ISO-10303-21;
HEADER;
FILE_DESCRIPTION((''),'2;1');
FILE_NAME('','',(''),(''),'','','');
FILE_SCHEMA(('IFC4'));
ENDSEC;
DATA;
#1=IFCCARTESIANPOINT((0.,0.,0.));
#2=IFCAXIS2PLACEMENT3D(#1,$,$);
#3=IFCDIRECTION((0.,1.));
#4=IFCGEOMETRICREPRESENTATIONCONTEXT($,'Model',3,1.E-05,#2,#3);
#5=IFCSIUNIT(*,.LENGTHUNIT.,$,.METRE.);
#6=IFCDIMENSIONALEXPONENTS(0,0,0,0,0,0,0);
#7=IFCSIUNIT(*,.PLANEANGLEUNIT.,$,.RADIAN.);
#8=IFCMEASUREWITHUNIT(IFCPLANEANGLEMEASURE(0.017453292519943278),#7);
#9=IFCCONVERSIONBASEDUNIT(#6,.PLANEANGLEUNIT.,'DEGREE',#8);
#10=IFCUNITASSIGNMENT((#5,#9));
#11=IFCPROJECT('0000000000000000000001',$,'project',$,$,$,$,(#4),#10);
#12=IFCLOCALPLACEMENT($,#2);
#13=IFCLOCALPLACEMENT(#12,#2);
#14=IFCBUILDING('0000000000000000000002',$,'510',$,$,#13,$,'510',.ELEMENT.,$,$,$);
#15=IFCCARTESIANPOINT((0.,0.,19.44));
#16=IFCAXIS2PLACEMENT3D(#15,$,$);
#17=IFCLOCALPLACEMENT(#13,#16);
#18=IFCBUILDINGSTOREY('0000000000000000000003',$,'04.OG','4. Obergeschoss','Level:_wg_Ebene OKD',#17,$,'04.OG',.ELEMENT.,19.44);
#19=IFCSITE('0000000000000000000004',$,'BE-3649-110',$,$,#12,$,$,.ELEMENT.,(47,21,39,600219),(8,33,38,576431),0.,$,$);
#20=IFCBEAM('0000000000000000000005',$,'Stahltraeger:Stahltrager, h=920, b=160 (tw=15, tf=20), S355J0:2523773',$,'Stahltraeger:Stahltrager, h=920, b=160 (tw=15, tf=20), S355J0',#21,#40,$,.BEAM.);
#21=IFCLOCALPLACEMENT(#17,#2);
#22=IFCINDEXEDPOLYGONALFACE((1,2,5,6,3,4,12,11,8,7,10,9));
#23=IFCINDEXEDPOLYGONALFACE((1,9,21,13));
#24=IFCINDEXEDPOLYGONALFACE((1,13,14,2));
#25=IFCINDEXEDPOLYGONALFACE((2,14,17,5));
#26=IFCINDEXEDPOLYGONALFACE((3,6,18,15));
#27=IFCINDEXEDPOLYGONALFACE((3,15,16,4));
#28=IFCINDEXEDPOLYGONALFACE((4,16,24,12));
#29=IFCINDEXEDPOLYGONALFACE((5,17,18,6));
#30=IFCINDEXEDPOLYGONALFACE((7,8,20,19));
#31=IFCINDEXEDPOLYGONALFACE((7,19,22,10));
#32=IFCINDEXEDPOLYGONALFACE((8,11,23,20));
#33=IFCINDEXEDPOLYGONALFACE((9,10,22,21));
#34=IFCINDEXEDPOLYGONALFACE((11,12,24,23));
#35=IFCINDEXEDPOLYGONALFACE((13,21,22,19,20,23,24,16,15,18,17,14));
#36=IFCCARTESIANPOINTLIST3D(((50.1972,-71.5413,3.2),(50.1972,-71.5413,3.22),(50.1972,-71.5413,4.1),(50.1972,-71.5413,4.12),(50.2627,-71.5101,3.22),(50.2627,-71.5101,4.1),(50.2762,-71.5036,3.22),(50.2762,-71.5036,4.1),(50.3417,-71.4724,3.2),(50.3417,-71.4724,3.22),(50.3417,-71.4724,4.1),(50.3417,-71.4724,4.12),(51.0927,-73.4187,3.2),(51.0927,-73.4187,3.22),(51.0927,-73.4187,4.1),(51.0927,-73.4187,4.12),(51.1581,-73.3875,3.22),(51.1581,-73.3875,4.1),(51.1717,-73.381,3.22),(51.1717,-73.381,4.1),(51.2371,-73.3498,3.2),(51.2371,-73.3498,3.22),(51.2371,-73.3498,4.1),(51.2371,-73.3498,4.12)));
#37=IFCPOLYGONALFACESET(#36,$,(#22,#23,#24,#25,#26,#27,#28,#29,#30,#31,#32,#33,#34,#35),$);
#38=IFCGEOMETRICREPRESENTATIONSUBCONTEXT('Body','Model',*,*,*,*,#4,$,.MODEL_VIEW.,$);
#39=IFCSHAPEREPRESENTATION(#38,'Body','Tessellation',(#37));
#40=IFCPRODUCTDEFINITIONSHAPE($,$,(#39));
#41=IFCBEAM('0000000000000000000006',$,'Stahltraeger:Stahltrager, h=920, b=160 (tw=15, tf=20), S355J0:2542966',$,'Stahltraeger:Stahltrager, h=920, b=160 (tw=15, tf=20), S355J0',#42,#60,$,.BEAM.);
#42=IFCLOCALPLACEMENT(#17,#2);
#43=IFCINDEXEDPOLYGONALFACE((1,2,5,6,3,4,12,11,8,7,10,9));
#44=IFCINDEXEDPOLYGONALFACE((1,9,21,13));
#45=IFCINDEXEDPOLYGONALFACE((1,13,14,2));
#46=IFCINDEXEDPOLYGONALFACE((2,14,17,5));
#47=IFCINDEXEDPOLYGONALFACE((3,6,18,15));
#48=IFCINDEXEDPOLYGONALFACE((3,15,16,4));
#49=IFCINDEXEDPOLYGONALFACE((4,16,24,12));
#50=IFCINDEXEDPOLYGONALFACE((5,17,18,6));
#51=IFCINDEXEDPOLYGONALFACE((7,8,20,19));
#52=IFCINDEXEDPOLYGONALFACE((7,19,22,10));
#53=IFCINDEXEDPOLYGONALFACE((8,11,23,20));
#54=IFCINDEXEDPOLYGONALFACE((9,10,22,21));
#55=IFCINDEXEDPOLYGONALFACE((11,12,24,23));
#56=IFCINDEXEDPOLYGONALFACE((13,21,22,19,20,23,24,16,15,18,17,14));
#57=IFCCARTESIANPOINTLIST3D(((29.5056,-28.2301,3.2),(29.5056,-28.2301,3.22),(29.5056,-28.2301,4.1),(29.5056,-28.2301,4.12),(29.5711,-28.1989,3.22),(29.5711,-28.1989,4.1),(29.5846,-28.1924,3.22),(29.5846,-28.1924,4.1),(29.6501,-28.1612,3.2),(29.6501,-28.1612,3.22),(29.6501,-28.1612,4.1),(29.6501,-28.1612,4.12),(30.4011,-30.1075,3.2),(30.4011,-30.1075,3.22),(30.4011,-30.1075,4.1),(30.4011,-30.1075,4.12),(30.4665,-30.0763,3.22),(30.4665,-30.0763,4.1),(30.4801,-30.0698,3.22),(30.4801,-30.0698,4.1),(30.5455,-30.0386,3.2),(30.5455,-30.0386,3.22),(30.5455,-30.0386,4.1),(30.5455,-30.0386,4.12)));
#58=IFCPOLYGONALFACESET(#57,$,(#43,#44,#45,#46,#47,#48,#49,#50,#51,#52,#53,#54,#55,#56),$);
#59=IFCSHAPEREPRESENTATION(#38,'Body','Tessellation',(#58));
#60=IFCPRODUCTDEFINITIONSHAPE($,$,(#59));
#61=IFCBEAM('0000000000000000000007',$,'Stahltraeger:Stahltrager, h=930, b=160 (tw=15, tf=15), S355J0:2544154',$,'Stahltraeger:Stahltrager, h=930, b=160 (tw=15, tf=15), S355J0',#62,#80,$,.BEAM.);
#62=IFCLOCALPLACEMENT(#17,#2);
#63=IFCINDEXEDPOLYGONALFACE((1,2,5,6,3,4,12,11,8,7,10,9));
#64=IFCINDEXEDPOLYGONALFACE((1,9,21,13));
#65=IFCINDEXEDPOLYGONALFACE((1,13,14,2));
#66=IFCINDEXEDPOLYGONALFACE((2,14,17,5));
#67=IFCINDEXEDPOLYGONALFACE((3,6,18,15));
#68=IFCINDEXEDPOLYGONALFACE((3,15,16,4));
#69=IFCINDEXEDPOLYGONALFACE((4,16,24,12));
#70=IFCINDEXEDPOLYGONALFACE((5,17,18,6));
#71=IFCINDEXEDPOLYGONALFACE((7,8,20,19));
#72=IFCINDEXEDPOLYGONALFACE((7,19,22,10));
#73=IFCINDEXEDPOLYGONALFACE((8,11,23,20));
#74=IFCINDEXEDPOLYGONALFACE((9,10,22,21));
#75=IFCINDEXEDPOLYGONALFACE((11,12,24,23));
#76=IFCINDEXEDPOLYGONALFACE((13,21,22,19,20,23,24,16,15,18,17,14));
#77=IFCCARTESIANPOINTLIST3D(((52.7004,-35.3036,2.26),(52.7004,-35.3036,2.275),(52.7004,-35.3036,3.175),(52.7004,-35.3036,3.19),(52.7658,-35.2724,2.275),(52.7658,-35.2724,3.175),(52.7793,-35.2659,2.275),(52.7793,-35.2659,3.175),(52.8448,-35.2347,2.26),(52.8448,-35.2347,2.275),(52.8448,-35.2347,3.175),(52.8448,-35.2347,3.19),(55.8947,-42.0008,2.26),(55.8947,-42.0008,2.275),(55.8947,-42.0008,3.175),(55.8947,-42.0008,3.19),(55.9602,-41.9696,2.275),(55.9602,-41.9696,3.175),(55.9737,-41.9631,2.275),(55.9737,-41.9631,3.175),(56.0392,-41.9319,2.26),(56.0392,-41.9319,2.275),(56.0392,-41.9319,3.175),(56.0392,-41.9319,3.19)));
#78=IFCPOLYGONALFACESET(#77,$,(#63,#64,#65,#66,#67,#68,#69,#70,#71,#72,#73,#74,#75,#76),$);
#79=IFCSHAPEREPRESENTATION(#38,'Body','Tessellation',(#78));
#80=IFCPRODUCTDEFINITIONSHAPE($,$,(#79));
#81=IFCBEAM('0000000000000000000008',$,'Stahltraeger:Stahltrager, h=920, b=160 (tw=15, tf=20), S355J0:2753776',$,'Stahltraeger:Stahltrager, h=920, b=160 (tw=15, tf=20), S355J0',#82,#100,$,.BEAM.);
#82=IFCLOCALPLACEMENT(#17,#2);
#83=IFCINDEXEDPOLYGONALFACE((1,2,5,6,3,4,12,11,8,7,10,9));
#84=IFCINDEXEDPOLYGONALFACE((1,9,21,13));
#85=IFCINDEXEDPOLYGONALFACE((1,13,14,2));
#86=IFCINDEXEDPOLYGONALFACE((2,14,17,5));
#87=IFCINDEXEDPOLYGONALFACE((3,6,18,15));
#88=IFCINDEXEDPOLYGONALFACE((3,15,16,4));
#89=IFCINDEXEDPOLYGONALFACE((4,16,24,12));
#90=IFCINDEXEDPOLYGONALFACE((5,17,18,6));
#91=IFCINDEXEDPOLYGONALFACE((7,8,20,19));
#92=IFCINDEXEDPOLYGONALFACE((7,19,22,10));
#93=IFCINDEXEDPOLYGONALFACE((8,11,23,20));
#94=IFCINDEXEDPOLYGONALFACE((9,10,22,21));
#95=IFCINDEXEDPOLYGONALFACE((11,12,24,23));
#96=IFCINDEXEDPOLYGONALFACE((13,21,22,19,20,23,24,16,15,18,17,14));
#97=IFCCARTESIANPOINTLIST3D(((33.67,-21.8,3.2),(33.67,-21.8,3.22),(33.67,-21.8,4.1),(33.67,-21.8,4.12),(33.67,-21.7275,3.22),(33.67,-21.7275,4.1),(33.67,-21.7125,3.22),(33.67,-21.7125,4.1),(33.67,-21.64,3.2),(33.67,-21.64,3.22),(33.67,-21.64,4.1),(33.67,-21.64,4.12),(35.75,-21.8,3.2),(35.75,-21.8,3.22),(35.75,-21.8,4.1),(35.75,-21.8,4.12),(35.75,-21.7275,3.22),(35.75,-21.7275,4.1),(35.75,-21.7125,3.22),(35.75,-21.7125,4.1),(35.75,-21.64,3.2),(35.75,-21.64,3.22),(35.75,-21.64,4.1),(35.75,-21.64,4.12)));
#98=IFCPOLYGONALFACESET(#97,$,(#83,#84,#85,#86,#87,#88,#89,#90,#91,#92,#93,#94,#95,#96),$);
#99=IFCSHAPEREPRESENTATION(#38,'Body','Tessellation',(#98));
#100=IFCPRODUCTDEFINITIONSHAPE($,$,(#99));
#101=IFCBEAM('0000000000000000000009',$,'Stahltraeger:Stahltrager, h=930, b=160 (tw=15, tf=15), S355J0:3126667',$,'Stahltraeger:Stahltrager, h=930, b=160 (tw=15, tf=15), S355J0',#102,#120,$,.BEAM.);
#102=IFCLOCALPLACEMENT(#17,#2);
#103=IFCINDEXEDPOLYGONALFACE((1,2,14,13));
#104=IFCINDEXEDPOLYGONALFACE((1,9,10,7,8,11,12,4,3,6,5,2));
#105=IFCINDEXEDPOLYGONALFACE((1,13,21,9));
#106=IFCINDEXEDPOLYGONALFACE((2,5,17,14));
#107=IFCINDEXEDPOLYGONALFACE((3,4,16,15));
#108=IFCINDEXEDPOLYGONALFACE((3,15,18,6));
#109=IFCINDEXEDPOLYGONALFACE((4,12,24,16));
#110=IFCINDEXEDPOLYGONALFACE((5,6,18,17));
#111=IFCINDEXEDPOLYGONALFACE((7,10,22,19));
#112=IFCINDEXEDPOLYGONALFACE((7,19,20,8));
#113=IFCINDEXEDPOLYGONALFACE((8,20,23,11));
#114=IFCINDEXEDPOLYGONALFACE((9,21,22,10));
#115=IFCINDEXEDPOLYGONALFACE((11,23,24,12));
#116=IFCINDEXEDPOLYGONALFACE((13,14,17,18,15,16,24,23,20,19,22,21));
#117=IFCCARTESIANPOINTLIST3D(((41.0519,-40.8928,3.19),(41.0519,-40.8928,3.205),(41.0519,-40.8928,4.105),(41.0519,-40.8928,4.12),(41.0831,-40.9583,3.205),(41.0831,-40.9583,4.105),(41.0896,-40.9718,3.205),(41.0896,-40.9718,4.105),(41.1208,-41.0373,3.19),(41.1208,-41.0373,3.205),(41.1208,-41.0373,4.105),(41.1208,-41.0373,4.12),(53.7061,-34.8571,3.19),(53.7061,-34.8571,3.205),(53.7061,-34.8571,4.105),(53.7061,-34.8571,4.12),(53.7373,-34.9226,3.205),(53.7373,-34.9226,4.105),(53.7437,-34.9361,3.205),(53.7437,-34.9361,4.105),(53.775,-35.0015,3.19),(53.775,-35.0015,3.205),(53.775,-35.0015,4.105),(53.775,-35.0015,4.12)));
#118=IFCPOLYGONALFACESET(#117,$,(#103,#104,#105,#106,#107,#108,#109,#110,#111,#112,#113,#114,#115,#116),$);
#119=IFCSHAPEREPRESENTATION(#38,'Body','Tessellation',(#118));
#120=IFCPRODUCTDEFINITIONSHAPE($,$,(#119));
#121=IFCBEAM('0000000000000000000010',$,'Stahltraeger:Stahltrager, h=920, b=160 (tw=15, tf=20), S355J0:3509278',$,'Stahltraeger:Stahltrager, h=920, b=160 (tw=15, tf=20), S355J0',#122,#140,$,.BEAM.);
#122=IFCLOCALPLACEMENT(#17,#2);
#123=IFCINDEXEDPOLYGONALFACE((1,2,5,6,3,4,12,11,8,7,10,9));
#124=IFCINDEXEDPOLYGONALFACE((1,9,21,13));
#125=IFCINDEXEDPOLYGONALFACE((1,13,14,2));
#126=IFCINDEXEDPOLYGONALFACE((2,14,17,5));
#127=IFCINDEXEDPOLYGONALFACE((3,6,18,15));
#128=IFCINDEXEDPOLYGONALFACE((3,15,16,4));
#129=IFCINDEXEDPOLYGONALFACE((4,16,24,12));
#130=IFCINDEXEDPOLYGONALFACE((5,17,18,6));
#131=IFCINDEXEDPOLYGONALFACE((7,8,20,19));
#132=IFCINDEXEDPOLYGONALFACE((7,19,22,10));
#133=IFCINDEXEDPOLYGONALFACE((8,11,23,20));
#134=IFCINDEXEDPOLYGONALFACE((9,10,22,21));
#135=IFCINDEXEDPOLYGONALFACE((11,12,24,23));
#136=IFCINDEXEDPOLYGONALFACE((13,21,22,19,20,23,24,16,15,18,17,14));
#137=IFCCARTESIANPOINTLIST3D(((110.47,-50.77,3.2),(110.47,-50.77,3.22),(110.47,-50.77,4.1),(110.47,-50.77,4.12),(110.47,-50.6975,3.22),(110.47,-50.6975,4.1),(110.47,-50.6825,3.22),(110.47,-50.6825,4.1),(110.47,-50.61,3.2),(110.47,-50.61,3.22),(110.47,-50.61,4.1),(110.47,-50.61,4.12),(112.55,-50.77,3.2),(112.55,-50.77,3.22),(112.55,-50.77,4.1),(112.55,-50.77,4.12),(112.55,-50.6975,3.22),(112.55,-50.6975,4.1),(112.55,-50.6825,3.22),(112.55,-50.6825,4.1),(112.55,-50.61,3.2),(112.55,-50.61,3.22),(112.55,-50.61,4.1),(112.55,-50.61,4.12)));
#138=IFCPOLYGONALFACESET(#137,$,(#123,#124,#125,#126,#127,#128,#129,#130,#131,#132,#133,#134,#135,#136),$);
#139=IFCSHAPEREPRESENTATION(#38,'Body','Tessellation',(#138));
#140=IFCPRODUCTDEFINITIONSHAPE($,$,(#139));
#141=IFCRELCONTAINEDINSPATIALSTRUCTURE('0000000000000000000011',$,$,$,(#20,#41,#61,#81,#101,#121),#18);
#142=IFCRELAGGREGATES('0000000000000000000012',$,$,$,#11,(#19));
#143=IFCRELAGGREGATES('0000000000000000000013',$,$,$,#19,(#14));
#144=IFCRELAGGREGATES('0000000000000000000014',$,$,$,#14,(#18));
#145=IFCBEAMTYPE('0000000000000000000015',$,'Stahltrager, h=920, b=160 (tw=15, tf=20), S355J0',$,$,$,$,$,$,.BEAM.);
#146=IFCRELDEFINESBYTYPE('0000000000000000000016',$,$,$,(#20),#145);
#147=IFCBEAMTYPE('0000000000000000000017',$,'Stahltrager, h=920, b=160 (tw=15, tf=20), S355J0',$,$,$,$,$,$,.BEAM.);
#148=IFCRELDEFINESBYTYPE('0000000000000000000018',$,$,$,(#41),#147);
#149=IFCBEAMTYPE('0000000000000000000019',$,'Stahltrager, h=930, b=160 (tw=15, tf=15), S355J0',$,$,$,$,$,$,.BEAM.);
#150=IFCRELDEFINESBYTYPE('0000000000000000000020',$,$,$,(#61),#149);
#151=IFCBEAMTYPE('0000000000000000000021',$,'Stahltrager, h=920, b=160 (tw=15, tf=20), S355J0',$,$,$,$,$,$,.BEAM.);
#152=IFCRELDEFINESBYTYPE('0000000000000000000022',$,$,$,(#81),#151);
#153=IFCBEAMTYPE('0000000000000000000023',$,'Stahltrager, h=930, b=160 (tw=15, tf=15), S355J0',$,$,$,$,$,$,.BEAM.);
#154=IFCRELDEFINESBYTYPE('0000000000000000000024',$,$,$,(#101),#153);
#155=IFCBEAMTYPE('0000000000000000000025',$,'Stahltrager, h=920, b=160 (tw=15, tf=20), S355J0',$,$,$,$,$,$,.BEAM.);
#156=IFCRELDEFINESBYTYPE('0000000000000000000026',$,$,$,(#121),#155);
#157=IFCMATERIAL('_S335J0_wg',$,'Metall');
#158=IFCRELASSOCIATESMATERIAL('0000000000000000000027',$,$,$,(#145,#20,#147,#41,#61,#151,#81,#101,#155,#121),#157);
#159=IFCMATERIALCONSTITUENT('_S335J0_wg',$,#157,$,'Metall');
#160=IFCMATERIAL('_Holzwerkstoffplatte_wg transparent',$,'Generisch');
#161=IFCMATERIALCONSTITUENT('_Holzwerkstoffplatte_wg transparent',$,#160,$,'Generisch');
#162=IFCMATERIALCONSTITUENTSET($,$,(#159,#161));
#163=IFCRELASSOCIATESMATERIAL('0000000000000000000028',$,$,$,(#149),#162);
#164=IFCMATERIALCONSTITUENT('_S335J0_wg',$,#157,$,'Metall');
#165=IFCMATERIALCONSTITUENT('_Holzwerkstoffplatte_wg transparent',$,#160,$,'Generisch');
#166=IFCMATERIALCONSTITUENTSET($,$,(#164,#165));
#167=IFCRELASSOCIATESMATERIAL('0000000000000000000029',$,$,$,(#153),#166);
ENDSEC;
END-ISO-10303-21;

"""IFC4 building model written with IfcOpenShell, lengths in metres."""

from ifc_helpers import new_model, entity, si_unit, converted_unit, direction, frame, origin, place, context, subcontext, project, spatial, indexed_curve, outline, extrude, source, transform, mapped, material, constituent, constituent_set, type_object, type_shapes, element, save


model = new_model("IFC4")

# Units and contexts
model_context = context("Model", 3, precision=1e-05, world=origin(), true_north=direction((0.0, 1.0)))
body_context = subcontext(model_context, "Body", "Model", "MODEL_VIEW")
ifc_project = project(units=[si_unit("LENGTHUNIT", "METRE"), converted_unit("PLANEANGLEUNIT", "DEGREE", entity("IfcPlaneAngleMeasure", 0.017453292519943278), si_unit("PLANEANGLEUNIT", "RADIAN"), dimensions=[0, 0, 0, 0, 0, 0, 0])], contexts=[model_context])

# Site, building, storey
site_placement = place(None, origin())
site = spatial("IfcSite", under=ifc_project, at=site_placement, Name="BE-3649-110", CompositionType="ELEMENT", RefLatitude=(47, 21, 39, 600219), RefLongitude=(8, 33, 38, 576431), RefElevation=0.0)
building_placement = place(site_placement, origin())
building = spatial("IfcBuilding", under=site, at=building_placement, Name="510", LongName="510", CompositionType="ELEMENT")
storey_placement = place(building_placement, frame((0.0, 0.0, 19.44)))
storey = spatial("IfcBuildingStorey", under=building, at=storey_placement, Name="04.OG", Description="4. Obergeschoss", ObjectType="Level:_wg_Ebene OKD", LongName="04.OG", CompositionType="ELEMENT", Elevation=19.44)

# Beams, openings
ifc_material_1 = material(Name="_S335J0_wg", Category="Metall")
beam_type_1 = type_object("IfcBeamType", Name="Stahltrager, h=920, b=160 (tw=15, tf=20), S355J0", PredefinedType="BEAM", material=ifc_material_1)
shared_shape_1 = source(origin(), body_context, "Body", "SweptSolid", [
    extrude(outline(indexed_curve([(-0.08, -0.44), (-0.08, -0.46), (0.08, -0.46), (0.08, -0.44), (0.0075, -0.44), (0.0075, 0.44), (0.08, 0.44), (0.08, 0.46), (-0.08, 0.46), (-0.08, 0.44), (-0.0075, 0.44), (-0.0075, -0.44), (-0.08, -0.44)], self_intersect=False)), frame((0.9677, 0.0344, 0.46), z_axis=(0.430511, -0.902585, 0.0), x_axis=(0.902585, 0.430511, 0.0)), (0.0, 0.0, -1.0), 2.08),
])
type_shapes(beam_type_1, [shared_shape_1])
beam_1_placement = place(storey_placement, frame((50.1972, -73.4187, 3.2)))
beam_1 = element("IfcBeam", 1, at=beam_1_placement, inside=storey, type_object=beam_type_1, material=ifc_material_1, Name="Stahltraeger:Stahltrager, h=920, b=160 (tw=15, tf=20), S355J0:2523773", ObjectType="Stahltraeger:Stahltrager, h=920, b=160 (tw=15, tf=20), S355J0", PredefinedType="BEAM", context=body_context, shape_type="MappedRepresentation", body=[
    mapped(shared_shape_1, transform((0.0, 0.0, 0.0), scale=1.0)),
])
opening_1_placement = place(storey_placement, frame((50.1972, -73.4187, 3.2)))
element("IfcOpeningElement", 2, at=opening_1_placement, cuts=beam_1, PredefinedType="OPENING", context=body_context, shape_type="SweptSolid", body=[
    extrude(outline(indexed_curve([(-0.32, -0.22), (0.32, -0.22), (0.32, 0.22), (-0.32, 0.22), (-0.32, -0.22)], self_intersect=False)), frame((0.5148, 0.9664, -19.0217), z_axis=(0.902585, 0.430511, 0.0), x_axis=(-0.430511, 0.902585, 0.0)), (0.0, 0.0, 1.0), 0.015),
])
beam_type_2 = type_object("IfcBeamType", Name="Stahltrager, h=920, b=160 (tw=15, tf=20), S355J0", PredefinedType="BEAM", material=ifc_material_1)
shared_shape_2 = source(origin(), body_context, "Body", "SweptSolid", [
    extrude(outline(indexed_curve([(-0.08, -0.44), (-0.08, -0.46), (0.08, -0.46), (0.08, -0.44), (0.0075, -0.44), (0.0075, 0.44), (0.08, 0.44), (0.08, 0.46), (-0.08, 0.46), (-0.08, 0.44), (-0.0075, 0.44), (-0.0075, -0.44), (-0.08, -0.44)], self_intersect=False)), frame((0.9677, 0.0344, 0.46), z_axis=(0.430511, -0.902585, 0.0), x_axis=(0.902585, 0.430511, 0.0)), (0.0, 0.0, -1.0), 2.08),
])
type_shapes(beam_type_2, [shared_shape_2])
beam_2_placement = place(storey_placement, frame((29.5056, -30.1075, 3.2)))
beam_2 = element("IfcBeam", 3, at=beam_2_placement, inside=storey, type_object=beam_type_2, material=ifc_material_1, Name="Stahltraeger:Stahltrager, h=920, b=160 (tw=15, tf=20), S355J0:2542966", ObjectType="Stahltraeger:Stahltrager, h=920, b=160 (tw=15, tf=20), S355J0", PredefinedType="BEAM", context=body_context, shape_type="MappedRepresentation", body=[
    mapped(shared_shape_2, transform((0.0, 0.0, 0.0), scale=1.0)),
])
opening_2_placement = place(storey_placement, frame((29.5056, -30.1075, 3.2)))
element("IfcOpeningElement", 4, at=opening_2_placement, cuts=beam_2, PredefinedType="OPENING", context=body_context, shape_type="SweptSolid", body=[
    extrude(outline(indexed_curve([(-0.32, -0.22), (0.32, -0.22), (0.32, 0.22), (-0.32, 0.22), (-0.32, -0.22)], self_intersect=False)), frame((0.5267, 0.9764, -18.92), z_axis=(-0.902585, -0.430511, 0.0), x_axis=(0.430511, -0.902585, 0.0)), (0.0, 0.0, 1.0), 0.015),
])

# Beam
ifc_constituent_1 = constituent(ifc_material_1, Name="_S335J0_wg", Category="Metall")
ifc_material_2 = material(Name="_Holzwerkstoffplatte_wg transparent", Category="Generisch")
ifc_constituent_2 = constituent(ifc_material_2, Name="_Holzwerkstoffplatte_wg transparent", Category="Generisch")
ifc_constituent_set_1 = constituent_set(constituents=[ifc_constituent_1, ifc_constituent_2])
beam_type_3 = type_object("IfcBeamType", Name="Stahltrager, h=930, b=160 (tw=15, tf=15), S355J0", PredefinedType="BEAM", material=ifc_constituent_set_1)
shared_shape_3 = source(origin(), body_context, "Body", "SweptSolid", [
    extrude(outline(indexed_curve([(-0.465, -0.08), (-0.45, -0.08), (-0.45, -0.0075), (0.45, -0.0075), (0.45, -0.08), (0.465, -0.08), (0.465, 0.08), (0.45, 0.08), (0.45, 0.0075), (-0.45, 0.0075), (-0.45, 0.08), (-0.465, 0.08), (-0.465, -0.08)], self_intersect=False)), frame((52.7726, -35.2691, 22.165), z_axis=(0.430511, -0.902585, 0.0), x_axis=(0.0, 0.0, -1.0)), (0.0, 0.0, 1.0), 7.42),
])
type_shapes(beam_type_3, [shared_shape_3])
beam_3_placement = place(storey_placement, frame((0.0, 0.0, -19.44)))
element("IfcBeam", 5, at=beam_3_placement, inside=storey, type_object=beam_type_3, material=ifc_material_1, Name="Stahltraeger:Stahltrager, h=930, b=160 (tw=15, tf=15), S355J0:2544154", ObjectType="Stahltraeger:Stahltrager, h=930, b=160 (tw=15, tf=15), S355J0", PredefinedType="BEAM", context=body_context, shape_type="MappedRepresentation", body=[
    mapped(shared_shape_3, transform((0.0, 0.0, 0.0), scale=1.0)),
])

# Beam, opening
beam_type_4 = type_object("IfcBeamType", Name="Stahltrager, h=920, b=160 (tw=15, tf=20), S355J0", PredefinedType="BEAM", material=ifc_material_1)
shared_shape_4 = source(origin(), body_context, "Body", "SweptSolid", [
    extrude(outline(indexed_curve([(-0.08, -0.44), (-0.08, -0.46), (0.08, -0.46), (0.08, -0.44), (0.0075, -0.44), (0.0075, 0.44), (0.08, 0.44), (0.08, 0.46), (-0.08, 0.46), (-0.08, 0.44), (-0.0075, 0.44), (-0.0075, -0.44), (-0.08, -0.44)], self_intersect=False)), frame((0.0, 0.08, 0.46), z_axis=(-1.0, 0.0, 0.0), x_axis=(0.0, -1.0, 0.0)), (0.0, 0.0, -1.0), 2.08),
])
type_shapes(beam_type_4, [shared_shape_4])
beam_4_placement = place(storey_placement, frame((33.67, -21.8, 3.2)))
beam_4 = element("IfcBeam", 6, at=beam_4_placement, inside=storey, type_object=beam_type_4, material=ifc_material_1, Name="Stahltraeger:Stahltrager, h=920, b=160 (tw=15, tf=20), S355J0:2753776", ObjectType="Stahltraeger:Stahltrager, h=920, b=160 (tw=15, tf=20), S355J0", PredefinedType="BEAM", context=body_context, shape_type="MappedRepresentation", body=[
    mapped(shared_shape_4, transform((0.0, 0.0, 0.0), scale=1.0)),
])
opening_3_placement = place(storey_placement, frame((33.67, -21.8, 3.2)))
element("IfcOpeningElement", 7, at=opening_3_placement, cuts=beam_4, PredefinedType="OPENING", context=body_context, shape_type="SweptSolid", body=[
    extrude(outline(indexed_curve([(-0.32, -0.22), (0.32, -0.22), (0.32, 0.22), (-0.32, 0.22), (-0.32, -0.22)], self_intersect=False)), frame((1.3687, 0.0725, -19.0), z_axis=(0.0, 1.0, 0.0), x_axis=(-1.0, 0.0, 0.0)), (0.0, 0.0, 1.0), 0.015),
])

# Beam
ifc_constituent_3 = constituent(ifc_material_1, Name="_S335J0_wg", Category="Metall")
ifc_constituent_4 = constituent(ifc_material_2, Name="_Holzwerkstoffplatte_wg transparent", Category="Generisch")
ifc_constituent_set_2 = constituent_set(constituents=[ifc_constituent_3, ifc_constituent_4])
beam_type_5 = type_object("IfcBeamType", Name="Stahltrager, h=930, b=160 (tw=15, tf=15), S355J0", PredefinedType="BEAM", material=ifc_constituent_set_2)
shared_shape_5 = source(origin(), body_context, "Body", "SweptSolid", [
    extrude(outline(indexed_curve([(0.45, -0.08), (0.465, -0.08), (0.465, 0.08), (0.45, 0.08), (0.45, 0.0075), (-0.45, 0.0075), (-0.45, 0.08), (-0.465, 0.08), (-0.465, -0.08), (-0.45, -0.08), (-0.45, -0.0075), (0.45, -0.0075), (0.45, -0.08)], self_intersect=False)), frame((41.0864, -40.9651, 23.095), z_axis=(0.902585, 0.430511, 0.0), x_axis=(0.0, 0.0, 1.0)), (0.0, 0.0, 1.0), 14.0199),
])
type_shapes(beam_type_5, [shared_shape_5])
beam_5_placement = place(storey_placement, frame((0.0, 0.0, -19.44)))
element("IfcBeam", 8, at=beam_5_placement, inside=storey, type_object=beam_type_5, material=ifc_material_1, Name="Stahltraeger:Stahltrager, h=930, b=160 (tw=15, tf=15), S355J0:3126667", ObjectType="Stahltraeger:Stahltrager, h=930, b=160 (tw=15, tf=15), S355J0", PredefinedType="BEAM", context=body_context, shape_type="MappedRepresentation", body=[
    mapped(shared_shape_5, transform((0.0, 0.0, 0.0), scale=1.0)),
])

# Beam, opening
beam_type_6 = type_object("IfcBeamType", Name="Stahltrager, h=920, b=160 (tw=15, tf=20), S355J0", PredefinedType="BEAM", material=ifc_material_1)
shared_shape_6 = source(origin(), body_context, "Body", "SweptSolid", [
    extrude(outline(indexed_curve([(-0.08, -0.44), (-0.08, -0.46), (0.08, -0.46), (0.08, -0.44), (0.0075, -0.44), (0.0075, 0.44), (0.08, 0.44), (0.08, 0.46), (-0.08, 0.46), (-0.08, 0.44), (-0.0075, 0.44), (-0.0075, -0.44), (-0.08, -0.44)], self_intersect=False)), frame((0.0, 0.08, 0.46), z_axis=(-1.0, 0.0, 0.0), x_axis=(0.0, -1.0, 0.0)), (0.0, 0.0, -1.0), 2.08),
])
type_shapes(beam_type_6, [shared_shape_6])
beam_6_placement = place(storey_placement, frame((110.47, -50.77, 3.2)))
beam_6 = element("IfcBeam", 9, at=beam_6_placement, inside=storey, type_object=beam_type_6, material=ifc_material_1, Name="Stahltraeger:Stahltrager, h=920, b=160 (tw=15, tf=20), S355J0:3509278", ObjectType="Stahltraeger:Stahltrager, h=920, b=160 (tw=15, tf=20), S355J0", PredefinedType="BEAM", context=body_context, shape_type="MappedRepresentation", body=[
    mapped(shared_shape_6, transform((0.0, 0.0, 0.0), scale=1.0)),
])
opening_4_placement = place(storey_placement, frame((110.47, -50.77, 3.2)))
element("IfcOpeningElement", 10, at=opening_4_placement, cuts=beam_6, PredefinedType="OPENING", context=body_context, shape_type="SweptSolid", body=[
    extrude(outline(indexed_curve([(-0.32, -0.22), (0.32, -0.22), (0.32, 0.22), (-0.32, 0.22), (-0.32, -0.22)], self_intersect=False)), frame((1.04, 0.0725, -19.0), z_axis=(0.0, 1.0, 0.0), x_axis=(-1.0, 0.0, 0.0)), (0.0, 0.0, 1.0), 0.015),
])

save(model, "model.ifc")
